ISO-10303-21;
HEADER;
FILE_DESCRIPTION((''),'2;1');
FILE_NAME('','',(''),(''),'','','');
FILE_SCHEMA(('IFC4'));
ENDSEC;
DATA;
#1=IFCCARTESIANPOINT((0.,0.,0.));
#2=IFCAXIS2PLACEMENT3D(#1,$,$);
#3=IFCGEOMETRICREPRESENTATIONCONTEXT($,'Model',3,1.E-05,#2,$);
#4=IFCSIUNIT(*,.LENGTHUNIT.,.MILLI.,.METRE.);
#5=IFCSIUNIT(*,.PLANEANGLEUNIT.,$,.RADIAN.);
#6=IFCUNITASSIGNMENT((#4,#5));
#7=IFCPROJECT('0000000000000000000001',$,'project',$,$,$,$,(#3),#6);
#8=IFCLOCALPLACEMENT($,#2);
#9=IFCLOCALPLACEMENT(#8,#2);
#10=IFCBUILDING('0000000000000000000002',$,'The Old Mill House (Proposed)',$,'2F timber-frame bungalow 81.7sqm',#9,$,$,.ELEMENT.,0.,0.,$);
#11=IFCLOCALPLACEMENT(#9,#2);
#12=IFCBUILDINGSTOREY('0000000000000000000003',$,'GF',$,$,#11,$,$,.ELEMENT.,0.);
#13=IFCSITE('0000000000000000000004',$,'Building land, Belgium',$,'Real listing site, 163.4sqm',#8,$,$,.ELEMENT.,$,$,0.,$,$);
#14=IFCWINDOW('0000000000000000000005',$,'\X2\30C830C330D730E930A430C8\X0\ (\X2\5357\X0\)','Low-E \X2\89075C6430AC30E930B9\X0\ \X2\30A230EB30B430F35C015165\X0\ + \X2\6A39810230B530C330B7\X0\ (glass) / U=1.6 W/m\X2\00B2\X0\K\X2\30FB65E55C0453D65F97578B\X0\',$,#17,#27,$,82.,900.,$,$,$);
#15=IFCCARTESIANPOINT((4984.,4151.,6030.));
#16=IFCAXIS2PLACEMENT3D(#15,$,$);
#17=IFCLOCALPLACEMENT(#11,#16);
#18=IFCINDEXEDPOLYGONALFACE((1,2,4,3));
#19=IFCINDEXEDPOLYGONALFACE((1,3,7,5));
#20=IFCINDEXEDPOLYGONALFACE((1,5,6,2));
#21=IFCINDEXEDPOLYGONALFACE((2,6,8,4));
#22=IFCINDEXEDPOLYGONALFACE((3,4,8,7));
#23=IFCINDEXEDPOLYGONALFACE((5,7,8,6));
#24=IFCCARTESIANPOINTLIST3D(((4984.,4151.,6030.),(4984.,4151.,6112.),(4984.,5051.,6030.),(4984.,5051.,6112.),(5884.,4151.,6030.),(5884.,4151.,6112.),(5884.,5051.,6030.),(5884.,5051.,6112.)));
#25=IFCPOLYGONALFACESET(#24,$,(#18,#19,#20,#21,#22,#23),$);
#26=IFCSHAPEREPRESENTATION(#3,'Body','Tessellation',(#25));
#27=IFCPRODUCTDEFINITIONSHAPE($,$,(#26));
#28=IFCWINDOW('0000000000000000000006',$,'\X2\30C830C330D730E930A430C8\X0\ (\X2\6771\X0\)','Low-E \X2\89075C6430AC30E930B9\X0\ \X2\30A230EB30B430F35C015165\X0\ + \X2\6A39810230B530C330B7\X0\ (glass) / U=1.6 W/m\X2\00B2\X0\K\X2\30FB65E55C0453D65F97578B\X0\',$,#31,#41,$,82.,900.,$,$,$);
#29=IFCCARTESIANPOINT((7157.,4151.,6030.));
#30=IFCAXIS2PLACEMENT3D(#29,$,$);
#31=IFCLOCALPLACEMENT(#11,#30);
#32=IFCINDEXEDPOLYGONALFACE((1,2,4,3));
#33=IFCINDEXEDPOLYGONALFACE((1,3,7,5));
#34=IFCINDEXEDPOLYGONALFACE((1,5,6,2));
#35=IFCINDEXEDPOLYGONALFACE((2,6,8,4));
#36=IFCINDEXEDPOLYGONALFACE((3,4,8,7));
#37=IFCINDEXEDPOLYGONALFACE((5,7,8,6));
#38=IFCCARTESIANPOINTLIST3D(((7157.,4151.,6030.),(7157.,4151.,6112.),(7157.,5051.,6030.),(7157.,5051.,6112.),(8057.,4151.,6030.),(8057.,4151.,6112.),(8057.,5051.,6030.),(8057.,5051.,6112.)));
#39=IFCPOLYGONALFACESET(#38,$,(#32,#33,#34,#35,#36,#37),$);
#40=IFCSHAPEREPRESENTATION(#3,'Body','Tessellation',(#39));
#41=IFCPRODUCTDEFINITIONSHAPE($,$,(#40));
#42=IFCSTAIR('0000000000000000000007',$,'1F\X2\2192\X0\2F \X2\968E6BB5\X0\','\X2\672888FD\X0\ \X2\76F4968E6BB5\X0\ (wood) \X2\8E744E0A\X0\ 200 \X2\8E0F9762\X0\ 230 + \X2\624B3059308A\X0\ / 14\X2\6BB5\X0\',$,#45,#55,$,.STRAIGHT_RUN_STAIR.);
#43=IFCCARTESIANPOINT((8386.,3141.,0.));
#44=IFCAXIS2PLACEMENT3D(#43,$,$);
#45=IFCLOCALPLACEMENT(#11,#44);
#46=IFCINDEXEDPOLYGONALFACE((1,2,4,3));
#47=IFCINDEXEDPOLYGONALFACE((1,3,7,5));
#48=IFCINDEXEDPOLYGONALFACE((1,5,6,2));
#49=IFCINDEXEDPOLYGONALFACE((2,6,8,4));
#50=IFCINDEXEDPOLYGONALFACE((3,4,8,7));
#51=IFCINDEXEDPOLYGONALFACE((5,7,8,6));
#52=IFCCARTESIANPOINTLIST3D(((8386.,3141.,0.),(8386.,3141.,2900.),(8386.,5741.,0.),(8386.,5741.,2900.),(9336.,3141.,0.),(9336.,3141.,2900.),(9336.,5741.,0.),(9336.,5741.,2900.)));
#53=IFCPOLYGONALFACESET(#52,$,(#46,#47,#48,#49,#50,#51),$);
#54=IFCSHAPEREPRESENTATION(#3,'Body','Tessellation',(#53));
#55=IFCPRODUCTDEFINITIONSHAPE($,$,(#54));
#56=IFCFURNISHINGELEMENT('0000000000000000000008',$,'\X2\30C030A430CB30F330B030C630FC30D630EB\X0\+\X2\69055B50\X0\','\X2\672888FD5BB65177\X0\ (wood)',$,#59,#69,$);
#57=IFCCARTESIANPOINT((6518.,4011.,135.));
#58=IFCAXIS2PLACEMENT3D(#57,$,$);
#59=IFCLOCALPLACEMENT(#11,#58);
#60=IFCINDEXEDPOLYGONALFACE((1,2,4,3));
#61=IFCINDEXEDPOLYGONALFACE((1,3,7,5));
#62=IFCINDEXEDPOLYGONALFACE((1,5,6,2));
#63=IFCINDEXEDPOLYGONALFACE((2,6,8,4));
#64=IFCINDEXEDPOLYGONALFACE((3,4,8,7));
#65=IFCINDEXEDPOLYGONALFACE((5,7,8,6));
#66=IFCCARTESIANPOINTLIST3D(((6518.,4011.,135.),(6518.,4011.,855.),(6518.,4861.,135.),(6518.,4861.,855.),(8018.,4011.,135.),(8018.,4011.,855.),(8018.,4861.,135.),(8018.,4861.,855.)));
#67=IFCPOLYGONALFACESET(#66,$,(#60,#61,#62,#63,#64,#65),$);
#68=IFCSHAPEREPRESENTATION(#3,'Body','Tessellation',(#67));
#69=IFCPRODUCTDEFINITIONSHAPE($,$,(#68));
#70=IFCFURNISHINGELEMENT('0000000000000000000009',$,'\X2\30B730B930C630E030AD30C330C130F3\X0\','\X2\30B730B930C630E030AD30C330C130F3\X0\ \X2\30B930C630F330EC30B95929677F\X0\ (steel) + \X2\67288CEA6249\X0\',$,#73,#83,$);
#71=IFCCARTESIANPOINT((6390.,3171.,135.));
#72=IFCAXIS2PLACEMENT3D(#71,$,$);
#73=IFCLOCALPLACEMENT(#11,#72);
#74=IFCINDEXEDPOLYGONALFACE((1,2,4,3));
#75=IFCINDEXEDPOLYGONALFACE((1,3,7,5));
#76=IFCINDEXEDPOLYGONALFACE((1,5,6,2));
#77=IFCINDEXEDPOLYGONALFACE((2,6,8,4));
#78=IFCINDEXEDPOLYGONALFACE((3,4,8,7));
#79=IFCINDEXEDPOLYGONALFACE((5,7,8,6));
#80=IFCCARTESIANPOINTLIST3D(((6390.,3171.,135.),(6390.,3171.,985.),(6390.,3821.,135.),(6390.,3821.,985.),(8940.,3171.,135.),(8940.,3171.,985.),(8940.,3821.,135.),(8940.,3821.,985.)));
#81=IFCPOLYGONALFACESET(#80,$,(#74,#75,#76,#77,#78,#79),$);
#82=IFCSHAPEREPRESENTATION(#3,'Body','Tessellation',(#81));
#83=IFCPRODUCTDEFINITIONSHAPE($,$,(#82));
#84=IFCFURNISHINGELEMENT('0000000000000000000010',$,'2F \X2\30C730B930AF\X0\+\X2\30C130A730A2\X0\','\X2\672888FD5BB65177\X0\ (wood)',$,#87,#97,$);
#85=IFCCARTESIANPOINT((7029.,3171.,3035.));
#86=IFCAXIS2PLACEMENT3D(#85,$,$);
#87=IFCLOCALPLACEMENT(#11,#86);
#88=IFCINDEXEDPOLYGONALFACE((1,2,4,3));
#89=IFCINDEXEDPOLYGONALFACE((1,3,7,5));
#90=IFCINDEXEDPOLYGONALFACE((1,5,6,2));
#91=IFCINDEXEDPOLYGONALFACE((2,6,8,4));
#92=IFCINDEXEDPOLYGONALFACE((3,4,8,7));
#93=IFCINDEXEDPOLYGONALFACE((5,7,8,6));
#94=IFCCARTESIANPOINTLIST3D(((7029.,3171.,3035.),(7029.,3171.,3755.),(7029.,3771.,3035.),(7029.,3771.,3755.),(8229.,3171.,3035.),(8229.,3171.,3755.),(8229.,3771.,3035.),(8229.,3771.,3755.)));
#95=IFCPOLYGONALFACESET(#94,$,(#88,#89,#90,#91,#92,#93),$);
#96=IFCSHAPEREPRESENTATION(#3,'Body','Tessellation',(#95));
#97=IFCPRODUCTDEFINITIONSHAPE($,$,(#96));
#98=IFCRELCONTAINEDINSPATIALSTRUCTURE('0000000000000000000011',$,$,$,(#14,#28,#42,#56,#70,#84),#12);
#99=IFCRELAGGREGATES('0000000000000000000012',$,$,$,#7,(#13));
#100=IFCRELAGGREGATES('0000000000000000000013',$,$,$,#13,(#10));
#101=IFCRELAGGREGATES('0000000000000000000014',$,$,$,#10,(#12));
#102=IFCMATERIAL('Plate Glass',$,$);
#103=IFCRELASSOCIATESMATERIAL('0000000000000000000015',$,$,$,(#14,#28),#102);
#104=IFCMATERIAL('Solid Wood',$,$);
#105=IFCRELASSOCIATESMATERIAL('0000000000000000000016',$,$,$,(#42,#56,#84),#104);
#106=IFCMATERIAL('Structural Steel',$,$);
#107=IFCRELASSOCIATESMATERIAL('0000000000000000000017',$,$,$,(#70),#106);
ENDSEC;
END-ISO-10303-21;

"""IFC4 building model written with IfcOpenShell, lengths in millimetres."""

from ifc_helpers import new_model, si_unit, frame, frame_2d, origin, place, context, project, spatial, rectangle, extrude, material, element, save


model = new_model("IFC4")

# Units and contexts
model_context = context("Model", 3, precision=1e-05, world=origin())
ifc_project = project(units=[si_unit("LENGTHUNIT", "METRE", prefix="MILLI"), si_unit("PLANEANGLEUNIT", "RADIAN")], contexts=[model_context])

# Site, building, storey
site_placement = place(None, origin())
site = spatial("IfcSite", under=ifc_project, at=site_placement, Name="Building land, Belgium", ObjectType="Real listing site, 163.4sqm", CompositionType="ELEMENT", RefElevation=0.0)
building_placement = place(site_placement, origin())
building = spatial("IfcBuilding", under=site, at=building_placement, Name="The Old Mill House (Proposed)", ObjectType="2F timber-frame bungalow 81.7sqm", CompositionType="ELEMENT", ElevationOfRefHeight=0.0, ElevationOfTerrain=0.0)
storey_placement = place(building_placement, origin())
storey = spatial("IfcBuildingStorey", under=building, at=storey_placement, Name="GF", CompositionType="ELEMENT", Elevation=0.0)

# Shared definitions
ifc_material_1 = material(Name="Solid Wood")

# Shared definitions
ifc_material_2 = material(Name="Plate Glass")

# Windows
window_1_placement = place(storey_placement, frame((4984.0, 4151.0, 6030.0)))
element("IfcWindow", 1, at=window_1_placement, inside=storey, material=ifc_material_2, Name="トップライト (南)", Description="Low-E 複層ガラス アルゴン封入 + 樹脂サッシ (glass) / U=1.6 W/m²K・日射取得型", OverallHeight=82.0, OverallWidth=900.0, context=model_context, shape_type="SweptSolid", body=[
    extrude(rectangle(XDim=900.0, YDim=900.0, at=frame_2d((450.0, 450.0))), frame((4984.0, 4151.0, 6030.0)), (0.0, 0.0, 1.0), 82.0),
])
window_2_placement = place(storey_placement, frame((7157.0, 4151.0, 6030.0)))
element("IfcWindow", 2, at=window_2_placement, inside=storey, material=ifc_material_2, Name="トップライト (東)", Description="Low-E 複層ガラス アルゴン封入 + 樹脂サッシ (glass) / U=1.6 W/m²K・日射取得型", OverallHeight=82.0, OverallWidth=900.0, context=model_context, shape_type="SweptSolid", body=[
    extrude(rectangle(XDim=900.0, YDim=900.0, at=frame_2d((450.0, 450.0))), frame((7157.0, 4151.0, 6030.0)), (0.0, 0.0, 1.0), 82.0),
])

# Stair
stair_placement = place(storey_placement, frame((8386.0, 3141.0, 0.0)))
element("IfcStair", 3, at=stair_placement, inside=storey, material=ifc_material_1, Name="1F→2F 階段", Description="木製 直階段 (wood) 蹴上 200 踏面 230 + 手すり / 14段", PredefinedType="STRAIGHT_RUN_STAIR", context=model_context, shape_type="SweptSolid", body=[
    extrude(rectangle(XDim=950.0, YDim=2600.0, at=frame_2d((475.0, 1300.0))), frame((8386.0, 3141.0, 0.0)), (0.0, 0.0, 1.0), 2900.0),
])

# Furnishing elements
furnishing_1_placement = place(storey_placement, frame((6518.0, 4011.0, 135.0)))
element("IfcFurnishingElement", 4, at=furnishing_1_placement, inside=storey, material=ifc_material_1, Name="ダイニングテーブル+椅子", Description="木製家具 (wood)", context=model_context, shape_type="SweptSolid", body=[
    extrude(rectangle(XDim=1500.0, YDim=850.0, at=frame_2d((750.0, 425.0))), frame((6518.0, 4011.0, 135.0)), (0.0, 0.0, 1.0), 720.0),
])
ifc_material_3 = material(Name="Structural Steel")
furnishing_2_placement = place(storey_placement, frame((6390.0, 3171.0, 135.0)))
element("IfcFurnishingElement", 5, at=furnishing_2_placement, inside=storey, material=ifc_material_3, Name="システムキッチン", Description="システムキッチン ステンレス天板 (steel) + 木質扉", context=model_context, shape_type="SweptSolid", body=[
    extrude(rectangle(XDim=2550.0, YDim=650.0, at=frame_2d((1275.0, 325.0))), frame((6390.0, 3171.0, 135.0)), (0.0, 0.0, 1.0), 850.0),
])
furnishing_3_placement = place(storey_placement, frame((7029.0, 3171.0, 3035.0)))
element("IfcFurnishingElement", 6, at=furnishing_3_placement, inside=storey, material=ifc_material_1, Name="2F デスク+チェア", Description="木製家具 (wood)", context=model_context, shape_type="SweptSolid", body=[
    extrude(rectangle(XDim=1200.0, YDim=600.0, at=frame_2d((600.0, 300.0))), frame((7029.0, 3171.0, 3035.0)), (0.0, 0.0, 1.0), 720.0),
])

save(model, "model.ifc")
